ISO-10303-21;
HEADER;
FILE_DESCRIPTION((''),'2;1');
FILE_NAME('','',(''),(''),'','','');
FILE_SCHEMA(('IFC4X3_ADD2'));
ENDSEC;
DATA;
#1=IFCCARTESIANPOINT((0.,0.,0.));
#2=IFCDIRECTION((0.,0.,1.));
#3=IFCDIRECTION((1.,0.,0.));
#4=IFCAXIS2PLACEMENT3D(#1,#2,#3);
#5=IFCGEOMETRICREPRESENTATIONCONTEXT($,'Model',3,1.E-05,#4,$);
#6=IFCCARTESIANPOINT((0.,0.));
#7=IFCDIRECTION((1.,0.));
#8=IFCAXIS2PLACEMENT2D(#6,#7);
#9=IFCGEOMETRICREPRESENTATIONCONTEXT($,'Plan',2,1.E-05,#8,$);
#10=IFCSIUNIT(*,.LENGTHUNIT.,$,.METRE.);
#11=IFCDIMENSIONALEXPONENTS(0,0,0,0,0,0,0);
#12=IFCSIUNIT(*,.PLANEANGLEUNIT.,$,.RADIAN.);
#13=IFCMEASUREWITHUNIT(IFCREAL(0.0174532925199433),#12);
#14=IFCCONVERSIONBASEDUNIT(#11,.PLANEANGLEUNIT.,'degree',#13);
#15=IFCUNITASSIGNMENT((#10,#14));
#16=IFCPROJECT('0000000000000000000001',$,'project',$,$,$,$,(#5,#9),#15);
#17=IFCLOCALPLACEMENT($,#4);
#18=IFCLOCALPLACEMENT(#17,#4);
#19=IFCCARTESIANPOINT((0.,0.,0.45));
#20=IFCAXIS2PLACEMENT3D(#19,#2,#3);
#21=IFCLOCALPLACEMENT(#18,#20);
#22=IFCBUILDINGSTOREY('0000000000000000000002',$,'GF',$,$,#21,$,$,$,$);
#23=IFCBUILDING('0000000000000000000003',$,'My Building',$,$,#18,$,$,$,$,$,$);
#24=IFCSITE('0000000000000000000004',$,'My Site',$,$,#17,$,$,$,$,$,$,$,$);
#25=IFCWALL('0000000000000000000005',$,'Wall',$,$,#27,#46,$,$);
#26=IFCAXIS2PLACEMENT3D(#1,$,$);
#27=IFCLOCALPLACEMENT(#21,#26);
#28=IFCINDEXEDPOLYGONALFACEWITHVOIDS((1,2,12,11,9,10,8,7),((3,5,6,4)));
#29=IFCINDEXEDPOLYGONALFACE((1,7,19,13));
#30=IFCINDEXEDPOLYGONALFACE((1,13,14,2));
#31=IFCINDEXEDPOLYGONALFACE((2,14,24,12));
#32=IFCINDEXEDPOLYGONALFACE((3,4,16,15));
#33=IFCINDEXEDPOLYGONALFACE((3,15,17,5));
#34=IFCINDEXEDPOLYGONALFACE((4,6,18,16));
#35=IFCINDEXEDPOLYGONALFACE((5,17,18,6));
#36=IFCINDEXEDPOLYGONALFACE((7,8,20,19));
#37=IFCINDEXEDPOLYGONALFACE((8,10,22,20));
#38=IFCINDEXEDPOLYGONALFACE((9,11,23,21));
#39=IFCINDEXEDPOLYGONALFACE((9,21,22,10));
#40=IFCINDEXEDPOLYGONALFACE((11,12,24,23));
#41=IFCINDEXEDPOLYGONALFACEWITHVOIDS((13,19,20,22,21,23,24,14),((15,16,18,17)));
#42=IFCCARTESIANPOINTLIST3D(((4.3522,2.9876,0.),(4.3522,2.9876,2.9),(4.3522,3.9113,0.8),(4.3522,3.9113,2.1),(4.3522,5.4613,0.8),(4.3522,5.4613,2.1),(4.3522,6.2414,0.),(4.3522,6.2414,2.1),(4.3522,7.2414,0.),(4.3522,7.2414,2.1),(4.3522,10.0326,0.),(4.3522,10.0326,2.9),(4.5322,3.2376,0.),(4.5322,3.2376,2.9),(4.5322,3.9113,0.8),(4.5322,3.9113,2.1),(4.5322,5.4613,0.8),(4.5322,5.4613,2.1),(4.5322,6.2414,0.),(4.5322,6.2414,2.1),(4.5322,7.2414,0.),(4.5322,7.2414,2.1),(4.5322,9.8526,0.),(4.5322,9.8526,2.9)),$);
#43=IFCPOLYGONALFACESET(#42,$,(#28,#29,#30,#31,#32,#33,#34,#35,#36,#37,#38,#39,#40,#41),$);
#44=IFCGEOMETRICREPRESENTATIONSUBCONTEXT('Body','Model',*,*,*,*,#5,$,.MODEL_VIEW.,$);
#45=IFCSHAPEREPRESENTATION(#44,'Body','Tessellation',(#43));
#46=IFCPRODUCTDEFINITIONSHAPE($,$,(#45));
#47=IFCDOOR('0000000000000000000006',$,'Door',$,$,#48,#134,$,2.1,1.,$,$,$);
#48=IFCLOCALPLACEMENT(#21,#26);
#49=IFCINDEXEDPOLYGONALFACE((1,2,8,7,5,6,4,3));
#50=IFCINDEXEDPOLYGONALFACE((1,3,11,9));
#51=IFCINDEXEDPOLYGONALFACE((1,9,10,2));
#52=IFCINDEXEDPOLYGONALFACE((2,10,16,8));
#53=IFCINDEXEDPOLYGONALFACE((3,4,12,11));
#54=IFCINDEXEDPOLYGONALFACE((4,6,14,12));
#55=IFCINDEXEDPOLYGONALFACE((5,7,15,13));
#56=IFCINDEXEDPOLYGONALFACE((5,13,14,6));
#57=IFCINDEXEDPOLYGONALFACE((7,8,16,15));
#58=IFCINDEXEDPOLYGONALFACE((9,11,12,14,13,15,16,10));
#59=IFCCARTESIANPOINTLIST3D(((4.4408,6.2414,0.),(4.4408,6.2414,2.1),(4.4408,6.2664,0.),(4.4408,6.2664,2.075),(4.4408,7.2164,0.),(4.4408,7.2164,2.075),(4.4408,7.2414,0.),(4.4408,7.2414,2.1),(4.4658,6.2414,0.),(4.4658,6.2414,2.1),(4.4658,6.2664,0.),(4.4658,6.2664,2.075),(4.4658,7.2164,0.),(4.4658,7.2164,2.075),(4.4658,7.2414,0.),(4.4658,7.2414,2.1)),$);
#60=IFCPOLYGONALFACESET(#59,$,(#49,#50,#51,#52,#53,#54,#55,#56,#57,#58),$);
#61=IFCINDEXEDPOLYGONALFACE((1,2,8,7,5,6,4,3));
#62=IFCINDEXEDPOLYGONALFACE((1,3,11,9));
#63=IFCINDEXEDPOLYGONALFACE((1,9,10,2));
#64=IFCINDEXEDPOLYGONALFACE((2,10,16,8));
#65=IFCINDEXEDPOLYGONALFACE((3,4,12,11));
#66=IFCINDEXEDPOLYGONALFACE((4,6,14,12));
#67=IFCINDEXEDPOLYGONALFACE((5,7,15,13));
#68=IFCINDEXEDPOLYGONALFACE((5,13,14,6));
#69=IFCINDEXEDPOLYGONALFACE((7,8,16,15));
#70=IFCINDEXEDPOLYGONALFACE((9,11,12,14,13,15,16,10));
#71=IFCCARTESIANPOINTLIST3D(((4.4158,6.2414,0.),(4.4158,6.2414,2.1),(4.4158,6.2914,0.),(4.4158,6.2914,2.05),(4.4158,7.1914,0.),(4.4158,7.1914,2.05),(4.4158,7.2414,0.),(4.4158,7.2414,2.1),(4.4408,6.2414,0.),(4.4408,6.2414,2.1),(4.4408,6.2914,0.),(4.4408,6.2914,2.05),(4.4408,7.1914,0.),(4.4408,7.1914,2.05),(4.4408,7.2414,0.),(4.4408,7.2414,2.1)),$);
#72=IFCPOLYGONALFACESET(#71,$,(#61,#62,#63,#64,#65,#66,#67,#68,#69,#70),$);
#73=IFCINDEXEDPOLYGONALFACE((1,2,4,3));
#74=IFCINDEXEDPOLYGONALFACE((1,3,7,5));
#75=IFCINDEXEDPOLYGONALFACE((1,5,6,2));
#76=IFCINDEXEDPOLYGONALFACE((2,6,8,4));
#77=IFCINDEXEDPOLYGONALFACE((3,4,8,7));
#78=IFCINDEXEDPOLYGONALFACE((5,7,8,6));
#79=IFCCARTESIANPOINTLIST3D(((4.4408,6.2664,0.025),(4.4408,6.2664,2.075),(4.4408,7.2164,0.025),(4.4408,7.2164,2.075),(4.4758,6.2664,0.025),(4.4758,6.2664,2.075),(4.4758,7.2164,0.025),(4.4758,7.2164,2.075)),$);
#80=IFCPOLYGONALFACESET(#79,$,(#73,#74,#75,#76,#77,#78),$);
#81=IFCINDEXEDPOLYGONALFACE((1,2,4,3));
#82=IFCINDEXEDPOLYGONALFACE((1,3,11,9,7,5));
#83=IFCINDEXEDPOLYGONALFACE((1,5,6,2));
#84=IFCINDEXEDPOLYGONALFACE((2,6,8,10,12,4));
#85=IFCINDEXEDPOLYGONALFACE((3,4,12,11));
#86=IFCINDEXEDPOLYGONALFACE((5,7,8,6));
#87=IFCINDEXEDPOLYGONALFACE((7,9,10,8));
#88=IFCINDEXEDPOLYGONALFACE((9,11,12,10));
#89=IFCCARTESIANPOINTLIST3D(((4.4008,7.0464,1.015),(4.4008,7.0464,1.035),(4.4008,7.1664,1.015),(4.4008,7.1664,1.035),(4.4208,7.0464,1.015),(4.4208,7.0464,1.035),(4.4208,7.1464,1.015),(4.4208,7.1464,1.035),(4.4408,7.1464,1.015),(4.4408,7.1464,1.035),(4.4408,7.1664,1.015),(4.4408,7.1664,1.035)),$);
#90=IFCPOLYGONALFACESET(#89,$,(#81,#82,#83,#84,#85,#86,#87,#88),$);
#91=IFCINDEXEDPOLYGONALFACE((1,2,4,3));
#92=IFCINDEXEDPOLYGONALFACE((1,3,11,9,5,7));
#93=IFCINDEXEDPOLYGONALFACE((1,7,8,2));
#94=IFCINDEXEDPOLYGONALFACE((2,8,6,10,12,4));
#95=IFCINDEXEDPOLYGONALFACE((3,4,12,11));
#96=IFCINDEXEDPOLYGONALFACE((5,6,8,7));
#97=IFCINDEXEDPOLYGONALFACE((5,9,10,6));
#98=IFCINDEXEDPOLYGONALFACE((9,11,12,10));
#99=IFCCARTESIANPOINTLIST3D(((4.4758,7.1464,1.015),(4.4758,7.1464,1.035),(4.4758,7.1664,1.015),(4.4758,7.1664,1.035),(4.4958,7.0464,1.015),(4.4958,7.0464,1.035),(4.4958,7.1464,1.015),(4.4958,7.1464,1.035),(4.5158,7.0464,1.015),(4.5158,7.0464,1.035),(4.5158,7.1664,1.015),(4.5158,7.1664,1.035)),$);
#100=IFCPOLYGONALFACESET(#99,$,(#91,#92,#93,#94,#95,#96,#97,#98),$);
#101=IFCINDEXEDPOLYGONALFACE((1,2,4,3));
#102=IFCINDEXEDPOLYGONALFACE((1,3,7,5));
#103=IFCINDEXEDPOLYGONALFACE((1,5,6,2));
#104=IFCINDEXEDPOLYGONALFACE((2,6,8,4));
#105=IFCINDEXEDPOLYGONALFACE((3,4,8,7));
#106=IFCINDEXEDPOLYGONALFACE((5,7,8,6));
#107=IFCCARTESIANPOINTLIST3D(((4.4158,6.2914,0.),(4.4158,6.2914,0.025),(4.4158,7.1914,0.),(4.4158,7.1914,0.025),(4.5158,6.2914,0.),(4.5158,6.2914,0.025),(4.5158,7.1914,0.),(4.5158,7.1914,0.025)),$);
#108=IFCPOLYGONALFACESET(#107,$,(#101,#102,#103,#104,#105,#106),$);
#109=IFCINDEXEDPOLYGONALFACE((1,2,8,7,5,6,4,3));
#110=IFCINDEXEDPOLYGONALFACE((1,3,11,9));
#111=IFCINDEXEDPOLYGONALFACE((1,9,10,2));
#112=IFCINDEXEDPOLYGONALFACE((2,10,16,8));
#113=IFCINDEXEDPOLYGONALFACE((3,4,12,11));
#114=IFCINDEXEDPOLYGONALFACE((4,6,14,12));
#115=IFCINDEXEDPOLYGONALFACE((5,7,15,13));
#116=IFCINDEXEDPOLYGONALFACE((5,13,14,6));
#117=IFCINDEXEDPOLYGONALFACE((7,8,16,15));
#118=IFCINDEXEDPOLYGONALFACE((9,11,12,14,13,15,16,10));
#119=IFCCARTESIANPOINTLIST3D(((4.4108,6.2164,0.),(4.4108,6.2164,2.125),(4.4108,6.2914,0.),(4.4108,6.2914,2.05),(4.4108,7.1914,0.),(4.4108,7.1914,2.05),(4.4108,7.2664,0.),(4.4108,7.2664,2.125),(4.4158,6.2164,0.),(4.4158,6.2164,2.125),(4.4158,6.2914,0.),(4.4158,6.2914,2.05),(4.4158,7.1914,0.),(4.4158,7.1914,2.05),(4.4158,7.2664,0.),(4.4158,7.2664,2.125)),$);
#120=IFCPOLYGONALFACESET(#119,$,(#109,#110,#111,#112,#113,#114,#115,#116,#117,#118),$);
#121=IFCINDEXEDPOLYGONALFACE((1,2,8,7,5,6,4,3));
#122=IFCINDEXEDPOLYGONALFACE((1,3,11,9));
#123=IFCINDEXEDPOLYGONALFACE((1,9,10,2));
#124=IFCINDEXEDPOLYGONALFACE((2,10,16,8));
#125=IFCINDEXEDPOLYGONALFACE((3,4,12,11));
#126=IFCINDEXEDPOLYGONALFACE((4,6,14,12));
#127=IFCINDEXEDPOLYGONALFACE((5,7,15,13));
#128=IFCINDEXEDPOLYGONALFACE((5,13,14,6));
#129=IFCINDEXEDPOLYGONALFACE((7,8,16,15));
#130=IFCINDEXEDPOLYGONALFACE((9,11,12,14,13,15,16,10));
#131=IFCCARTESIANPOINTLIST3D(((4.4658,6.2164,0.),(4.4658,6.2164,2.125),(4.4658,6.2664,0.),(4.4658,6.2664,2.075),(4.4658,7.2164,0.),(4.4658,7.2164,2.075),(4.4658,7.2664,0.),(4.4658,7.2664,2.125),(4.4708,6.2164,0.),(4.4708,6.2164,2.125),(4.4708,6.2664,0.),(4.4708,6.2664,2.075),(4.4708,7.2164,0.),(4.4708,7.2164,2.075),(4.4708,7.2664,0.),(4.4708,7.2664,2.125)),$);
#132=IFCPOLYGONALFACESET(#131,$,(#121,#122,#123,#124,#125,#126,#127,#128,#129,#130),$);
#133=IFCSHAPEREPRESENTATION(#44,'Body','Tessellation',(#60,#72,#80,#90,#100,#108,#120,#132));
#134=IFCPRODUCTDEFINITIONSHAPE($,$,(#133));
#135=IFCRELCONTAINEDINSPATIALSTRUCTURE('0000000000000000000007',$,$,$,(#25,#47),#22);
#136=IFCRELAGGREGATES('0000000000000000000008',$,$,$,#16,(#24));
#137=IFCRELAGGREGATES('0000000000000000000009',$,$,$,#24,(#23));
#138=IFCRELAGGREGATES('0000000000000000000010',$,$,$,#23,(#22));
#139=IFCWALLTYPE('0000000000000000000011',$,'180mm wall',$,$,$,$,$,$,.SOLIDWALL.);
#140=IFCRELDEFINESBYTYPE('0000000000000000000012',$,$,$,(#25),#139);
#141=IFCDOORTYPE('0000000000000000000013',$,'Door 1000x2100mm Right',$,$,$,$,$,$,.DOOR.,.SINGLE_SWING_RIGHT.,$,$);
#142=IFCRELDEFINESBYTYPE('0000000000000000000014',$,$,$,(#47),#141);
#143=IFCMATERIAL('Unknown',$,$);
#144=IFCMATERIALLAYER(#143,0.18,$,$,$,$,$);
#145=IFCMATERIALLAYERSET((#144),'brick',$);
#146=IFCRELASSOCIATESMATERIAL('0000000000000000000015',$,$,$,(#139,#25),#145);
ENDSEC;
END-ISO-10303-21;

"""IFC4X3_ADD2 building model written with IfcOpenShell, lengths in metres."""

from ifc_helpers import new_model, entity, si_unit, converted_unit, frame, origin_with_axes, origin_2d_with_axis, place, context, subcontext, project, spatial, line, indexed_curve, outline, extrude, shape, source, transform, mapped, material, layer, layer_set, layer_usage, type_object, type_shapes, element, fill, save


model = new_model("IFC4X3_ADD2")

# Units and contexts
model_context = context("Model", 3, precision=1e-05, world=origin_with_axes())
plan_context = context("Plan", 2, precision=1e-05, world=origin_2d_with_axis())
body_context_1 = subcontext(model_context, "Body", "Model", "MODEL_VIEW")
body_context_2 = subcontext(plan_context, "Body", "Plan", "PLAN_VIEW")
ifc_project = project(units=[si_unit("LENGTHUNIT", "METRE"), converted_unit("PLANEANGLEUNIT", "degree", entity("IfcReal", 0.0174532925199433), si_unit("PLANEANGLEUNIT", "RADIAN"), dimensions=[0, 0, 0, 0, 0, 0, 0])], contexts=[model_context, plan_context])

# Site, building, storey
site_placement = place(None, origin_with_axes())
site = spatial("IfcSite", under=ifc_project, at=site_placement, Name="My Site")
building_placement = place(site_placement, origin_with_axes())
building = spatial("IfcBuilding", under=site, at=building_placement, Name="My Building")
storey_placement = place(building_placement, frame((0.0, 0.0, 0.45), z_axis=(0.0, 0.0, 1.0), x_axis=(1.0, 0.0, 0.0)))
storey = spatial("IfcBuildingStorey", under=building, at=storey_placement, Name="GF")

# Wall, openings, door
ifc_material_1 = material(Name="Unknown")
ifc_layer_1 = layer(ifc_material_1, 0.18)
ifc_layer_set_1 = layer_set([ifc_layer_1], Name="brick")
ifc_layer_usage_1 = layer_usage(ifc_layer_set_1, "AXIS2", "POSITIVE", 0.0)
wall_type = type_object("IfcWallType", Name="180mm wall", PredefinedType="SOLIDWALL", material=ifc_layer_set_1)
wall_placement = place(storey_placement, frame((4.5322, 2.9876, 0.0), z_axis=(0.0, 0.0, 1.0), x_axis=(0.0, 1.0, 0.0)))
wall = element("IfcWall", 1, at=wall_placement, inside=storey, type_object=wall_type, material=ifc_layer_usage_1, Name="Wall", context=body_context_1, shape_type="SweptSolid", body=[
    extrude(outline(indexed_curve([(0.25, 0.0), (0.0, 0.18), (7.045, 0.18), (6.865, 0.0)], segments=[line(1, 2, 3, 4, 1)])), origin_with_axes(), (0.0, 0.0, 1.0), 2.9),
])
shared_shape_1 = source(origin_with_axes(), body_context_1, "Body", "SolidModel", [
    extrude(outline(indexed_curve([(0.0, 0.0), (1.0, 0.0), (1.0, 2.1), (0.0, 2.1)], segments=[line(1, 2, 3, 4, 1)])), frame((0.0, -0.6, 0.0), z_axis=(0.0, -1.0, 0.0), x_axis=(1.0, 0.0, 0.0)), (0.0, 0.0, -1.0), 1.2),
])
opening_1_placement = place(wall_placement, frame((4.2539, 0.1164, 0.0), z_axis=(0.0, 0.0, 1.0), x_axis=(-1.0, 0.0, 0.0)))
opening_1 = element("IfcOpeningElement", 2, at=opening_1_placement, cuts=wall, PredefinedType="OPENING", context=body_context_1, shape_type="MappedRepresentation", body=[
    mapped(shared_shape_1, transform((0.0, 0.0, 0.0), x_axis=(1.0, 0.0, 0.0), y_axis=(0.0, 1.0, 0.0), z_axis=(0.0, 0.0, 1.0), scale=1.0)),
])
shared_shape_2 = source(origin_with_axes(), body_context_1, "Body", "SweptSolid", [
    extrude(outline(indexed_curve([(0.0, 0.0), (1.55, 0.0), (1.55, 1.3), (0.0, 1.3)], segments=[line(1, 2, 3, 4, 1)])), frame((-0.775, -0.6, 0.0), z_axis=(0.0, -1.0, 0.0), x_axis=(1.0, 0.0, 0.0)), (0.0, 0.0, -1.0), 1.2),
])
opening_2_placement = place(wall_placement, frame((1.6987, 0.0, 0.8), z_axis=(0.0, 0.0, 1.0), x_axis=(1.0, 0.0, 0.0)))
element("IfcOpeningElement", 3, at=opening_2_placement, cuts=wall, PredefinedType="OPENING", context=body_context_1, shape_type="MappedRepresentation", body=[
    mapped(shared_shape_2, transform((0.0, 0.0, 0.0), x_axis=(1.0, 0.0, 0.0), y_axis=(0.0, 1.0, 0.0), z_axis=(0.0, 0.0, 1.0), scale=1.0)),
])
door_type = type_object("IfcDoorType", Name="Door 1000x2100mm Right", OperationType="SINGLE_SWING_RIGHT", PredefinedType="DOOR")
shared_shape_3 = source(origin_with_axes(), body_context_1, "Body", "SweptSolid", [
    extrude(outline(indexed_curve([(0.0, 0.0), (0.0, 2.1), (1.0, 2.1), (1.0, 0.0), (0.975, 0.0), (0.975, 2.075), (0.025, 2.075), (0.025, 0.0)], segments=[line(1, 2, 3, 4, 5, 6, 7, 8, 1)])), frame((0.0, 0.025, 0.0), z_axis=(0.0, -1.0, 0.0), x_axis=(1.0, 0.0, 0.0)), (0.0, 0.0, -1.0), 0.025),
    extrude(outline(indexed_curve([(0.0, 0.0), (0.0, 2.1), (1.0, 2.1), (1.0, 0.0), (0.95, 0.0), (0.95, 2.05), (0.05, 2.05), (0.05, 0.0)], segments=[line(1, 2, 3, 4, 5, 6, 7, 8, 1)])), frame((0.0, 0.0, 0.0), z_axis=(0.0, -1.0, 0.0), x_axis=(1.0, 0.0, 0.0)), (0.0, 0.0, -1.0), 0.025),
    extrude(outline(indexed_curve([(0.0, 0.0), (0.95, 0.0), (0.95, 0.035), (0.0, 0.035)], segments=[line(1, 2, 3, 4, 1)])), frame((0.025, 0.025, 0.025), z_axis=(0.0, 0.0, 1.0), x_axis=(1.0, 0.0, 0.0)), (0.0, 0.0, 1.0), 2.05),
    extrude(outline(indexed_curve([(0.0, 0.0), (0.0, -0.04), (0.12, -0.04), (0.12, -0.02), (0.02, -0.02), (0.02, 0.0)], segments=[line(1, 2, 3, 4, 5, 6, 1)])), frame((0.075, 0.025, 1.015), z_axis=(0.0, 0.0, 1.0), x_axis=(1.0, 0.0, 0.0)), (0.0, 0.0, 1.0), 0.02),
    extrude(outline(indexed_curve([(0.0, 0.0), (0.0, 0.04), (0.12, 0.04), (0.12, 0.02), (0.02, 0.02), (0.02, 0.0)], segments=[line(1, 2, 3, 4, 5, 6, 1)])), frame((0.075, 0.06, 1.015), z_axis=(0.0, 0.0, 1.0), x_axis=(1.0, 0.0, 0.0)), (0.0, 0.0, 1.0), 0.02),
    extrude(outline(indexed_curve([(0.0, 0.0), (0.9, 0.0), (0.9, 0.1), (0.0, 0.1)], segments=[line(1, 2, 3, 4, 1)])), frame((0.05, 0.0, 0.0), z_axis=(0.0, 0.0, 1.0), x_axis=(1.0, 0.0, 0.0)), (0.0, 0.0, 1.0), 0.025),
    extrude(outline(indexed_curve([(0.0, 0.0), (0.0, 2.125), (1.05, 2.125), (1.05, 0.0), (0.975, 0.0), (0.975, 2.05), (0.075, 2.05), (0.075, 0.0)], segments=[line(1, 2, 3, 4, 5, 6, 7, 8, 1)])), frame((-0.025, -0.005, 0.0), z_axis=(0.0, -1.0, 0.0), x_axis=(1.0, 0.0, 0.0)), (0.0, 0.0, -1.0), 0.005),
    extrude(outline(indexed_curve([(0.0, 0.0), (0.0, 2.125), (1.05, 2.125), (1.05, 0.0), (1.0, 0.0), (1.0, 2.075), (0.05, 2.075), (0.05, 0.0)], segments=[line(1, 2, 3, 4, 5, 6, 7, 8, 1)])), frame((-0.025, 0.05, 0.0), z_axis=(0.0, -1.0, 0.0), x_axis=(1.0, 0.0, 0.0)), (0.0, 0.0, -1.0), 0.005),
])
shared_shape_4 = source(origin_with_axes(), body_context_2, "Body", "Curve2D", [
    entity("IfcIndexedPolyCurve", entity("IfcCartesianPointList2D", [[0.0, 0.0], [0.0, 0.05], [0.025, 0.05], [0.025, 0.025], [0.05, 0.025], [0.05, 0.0]]), [entity("IfcLineIndex", [1, 2, 3, 4, 5, 6, 1])]),
    entity("IfcIndexedPolyCurve", entity("IfcCartesianPointList2D", [[1.0, 0.0], [1.0, 0.05], [0.975, 0.05], [0.975, 0.025], [0.95, 0.025], [0.95, 0.0]]), [entity("IfcLineIndex", [1, 2, 3, 4, 5, 6, 1])]),
    entity("IfcTrimmedCurve", entity("IfcEllipse", entity("IfcAxis2Placement2D", entity("IfcCartesianPoint", [0.94, 0.05]), entity("IfcDirection", [1.0, 0.0])), 0.915, 0.95), [entity("IfcCartesianPoint", [0.94, 1.0])], [entity("IfcCartesianPoint", [0.025, 0.05])], True, "CARTESIAN"),
    entity("IfcIndexedPolyCurve", entity("IfcCartesianPointList2D", [[0.975, 0.05], [0.94, 0.05], [0.94, 1.0], [0.975, 1.0]]), [entity("IfcLineIndex", [1, 2, 3, 4, 1])]),
])
type_shapes(door_type, [shared_shape_3, shared_shape_4])
door_placement = place(opening_1_placement, frame((0.0, 0.0, 0.0), z_axis=(0.0, 0.0, 1.0), x_axis=(1.0, 0.0, 0.0)))
door = element("IfcDoor", 4, at=door_placement, inside=storey, type_object=door_type, Name="Door", OverallHeight=2.1, OverallWidth=1.0, shapes=[
    shape(body_context_1, "Body", "MappedRepresentation", [mapped(shared_shape_3, transform((0.0, 0.0, 0.0), x_axis=(1.0, 0.0, 0.0), y_axis=(0.0, 1.0, 0.0), z_axis=(0.0, 0.0, 1.0), scale=1.0))]),
    shape(body_context_2, "Body", "MappedRepresentation", [mapped(shared_shape_4, transform((0.0, 0.0, 0.0), x_axis=(1.0, 0.0, 0.0), y_axis=(0.0, 1.0, 0.0), z_axis=(0.0, 0.0, 1.0), scale=1.0))]),
])
fill(opening_1, door)

save(model, "model.ifc")
